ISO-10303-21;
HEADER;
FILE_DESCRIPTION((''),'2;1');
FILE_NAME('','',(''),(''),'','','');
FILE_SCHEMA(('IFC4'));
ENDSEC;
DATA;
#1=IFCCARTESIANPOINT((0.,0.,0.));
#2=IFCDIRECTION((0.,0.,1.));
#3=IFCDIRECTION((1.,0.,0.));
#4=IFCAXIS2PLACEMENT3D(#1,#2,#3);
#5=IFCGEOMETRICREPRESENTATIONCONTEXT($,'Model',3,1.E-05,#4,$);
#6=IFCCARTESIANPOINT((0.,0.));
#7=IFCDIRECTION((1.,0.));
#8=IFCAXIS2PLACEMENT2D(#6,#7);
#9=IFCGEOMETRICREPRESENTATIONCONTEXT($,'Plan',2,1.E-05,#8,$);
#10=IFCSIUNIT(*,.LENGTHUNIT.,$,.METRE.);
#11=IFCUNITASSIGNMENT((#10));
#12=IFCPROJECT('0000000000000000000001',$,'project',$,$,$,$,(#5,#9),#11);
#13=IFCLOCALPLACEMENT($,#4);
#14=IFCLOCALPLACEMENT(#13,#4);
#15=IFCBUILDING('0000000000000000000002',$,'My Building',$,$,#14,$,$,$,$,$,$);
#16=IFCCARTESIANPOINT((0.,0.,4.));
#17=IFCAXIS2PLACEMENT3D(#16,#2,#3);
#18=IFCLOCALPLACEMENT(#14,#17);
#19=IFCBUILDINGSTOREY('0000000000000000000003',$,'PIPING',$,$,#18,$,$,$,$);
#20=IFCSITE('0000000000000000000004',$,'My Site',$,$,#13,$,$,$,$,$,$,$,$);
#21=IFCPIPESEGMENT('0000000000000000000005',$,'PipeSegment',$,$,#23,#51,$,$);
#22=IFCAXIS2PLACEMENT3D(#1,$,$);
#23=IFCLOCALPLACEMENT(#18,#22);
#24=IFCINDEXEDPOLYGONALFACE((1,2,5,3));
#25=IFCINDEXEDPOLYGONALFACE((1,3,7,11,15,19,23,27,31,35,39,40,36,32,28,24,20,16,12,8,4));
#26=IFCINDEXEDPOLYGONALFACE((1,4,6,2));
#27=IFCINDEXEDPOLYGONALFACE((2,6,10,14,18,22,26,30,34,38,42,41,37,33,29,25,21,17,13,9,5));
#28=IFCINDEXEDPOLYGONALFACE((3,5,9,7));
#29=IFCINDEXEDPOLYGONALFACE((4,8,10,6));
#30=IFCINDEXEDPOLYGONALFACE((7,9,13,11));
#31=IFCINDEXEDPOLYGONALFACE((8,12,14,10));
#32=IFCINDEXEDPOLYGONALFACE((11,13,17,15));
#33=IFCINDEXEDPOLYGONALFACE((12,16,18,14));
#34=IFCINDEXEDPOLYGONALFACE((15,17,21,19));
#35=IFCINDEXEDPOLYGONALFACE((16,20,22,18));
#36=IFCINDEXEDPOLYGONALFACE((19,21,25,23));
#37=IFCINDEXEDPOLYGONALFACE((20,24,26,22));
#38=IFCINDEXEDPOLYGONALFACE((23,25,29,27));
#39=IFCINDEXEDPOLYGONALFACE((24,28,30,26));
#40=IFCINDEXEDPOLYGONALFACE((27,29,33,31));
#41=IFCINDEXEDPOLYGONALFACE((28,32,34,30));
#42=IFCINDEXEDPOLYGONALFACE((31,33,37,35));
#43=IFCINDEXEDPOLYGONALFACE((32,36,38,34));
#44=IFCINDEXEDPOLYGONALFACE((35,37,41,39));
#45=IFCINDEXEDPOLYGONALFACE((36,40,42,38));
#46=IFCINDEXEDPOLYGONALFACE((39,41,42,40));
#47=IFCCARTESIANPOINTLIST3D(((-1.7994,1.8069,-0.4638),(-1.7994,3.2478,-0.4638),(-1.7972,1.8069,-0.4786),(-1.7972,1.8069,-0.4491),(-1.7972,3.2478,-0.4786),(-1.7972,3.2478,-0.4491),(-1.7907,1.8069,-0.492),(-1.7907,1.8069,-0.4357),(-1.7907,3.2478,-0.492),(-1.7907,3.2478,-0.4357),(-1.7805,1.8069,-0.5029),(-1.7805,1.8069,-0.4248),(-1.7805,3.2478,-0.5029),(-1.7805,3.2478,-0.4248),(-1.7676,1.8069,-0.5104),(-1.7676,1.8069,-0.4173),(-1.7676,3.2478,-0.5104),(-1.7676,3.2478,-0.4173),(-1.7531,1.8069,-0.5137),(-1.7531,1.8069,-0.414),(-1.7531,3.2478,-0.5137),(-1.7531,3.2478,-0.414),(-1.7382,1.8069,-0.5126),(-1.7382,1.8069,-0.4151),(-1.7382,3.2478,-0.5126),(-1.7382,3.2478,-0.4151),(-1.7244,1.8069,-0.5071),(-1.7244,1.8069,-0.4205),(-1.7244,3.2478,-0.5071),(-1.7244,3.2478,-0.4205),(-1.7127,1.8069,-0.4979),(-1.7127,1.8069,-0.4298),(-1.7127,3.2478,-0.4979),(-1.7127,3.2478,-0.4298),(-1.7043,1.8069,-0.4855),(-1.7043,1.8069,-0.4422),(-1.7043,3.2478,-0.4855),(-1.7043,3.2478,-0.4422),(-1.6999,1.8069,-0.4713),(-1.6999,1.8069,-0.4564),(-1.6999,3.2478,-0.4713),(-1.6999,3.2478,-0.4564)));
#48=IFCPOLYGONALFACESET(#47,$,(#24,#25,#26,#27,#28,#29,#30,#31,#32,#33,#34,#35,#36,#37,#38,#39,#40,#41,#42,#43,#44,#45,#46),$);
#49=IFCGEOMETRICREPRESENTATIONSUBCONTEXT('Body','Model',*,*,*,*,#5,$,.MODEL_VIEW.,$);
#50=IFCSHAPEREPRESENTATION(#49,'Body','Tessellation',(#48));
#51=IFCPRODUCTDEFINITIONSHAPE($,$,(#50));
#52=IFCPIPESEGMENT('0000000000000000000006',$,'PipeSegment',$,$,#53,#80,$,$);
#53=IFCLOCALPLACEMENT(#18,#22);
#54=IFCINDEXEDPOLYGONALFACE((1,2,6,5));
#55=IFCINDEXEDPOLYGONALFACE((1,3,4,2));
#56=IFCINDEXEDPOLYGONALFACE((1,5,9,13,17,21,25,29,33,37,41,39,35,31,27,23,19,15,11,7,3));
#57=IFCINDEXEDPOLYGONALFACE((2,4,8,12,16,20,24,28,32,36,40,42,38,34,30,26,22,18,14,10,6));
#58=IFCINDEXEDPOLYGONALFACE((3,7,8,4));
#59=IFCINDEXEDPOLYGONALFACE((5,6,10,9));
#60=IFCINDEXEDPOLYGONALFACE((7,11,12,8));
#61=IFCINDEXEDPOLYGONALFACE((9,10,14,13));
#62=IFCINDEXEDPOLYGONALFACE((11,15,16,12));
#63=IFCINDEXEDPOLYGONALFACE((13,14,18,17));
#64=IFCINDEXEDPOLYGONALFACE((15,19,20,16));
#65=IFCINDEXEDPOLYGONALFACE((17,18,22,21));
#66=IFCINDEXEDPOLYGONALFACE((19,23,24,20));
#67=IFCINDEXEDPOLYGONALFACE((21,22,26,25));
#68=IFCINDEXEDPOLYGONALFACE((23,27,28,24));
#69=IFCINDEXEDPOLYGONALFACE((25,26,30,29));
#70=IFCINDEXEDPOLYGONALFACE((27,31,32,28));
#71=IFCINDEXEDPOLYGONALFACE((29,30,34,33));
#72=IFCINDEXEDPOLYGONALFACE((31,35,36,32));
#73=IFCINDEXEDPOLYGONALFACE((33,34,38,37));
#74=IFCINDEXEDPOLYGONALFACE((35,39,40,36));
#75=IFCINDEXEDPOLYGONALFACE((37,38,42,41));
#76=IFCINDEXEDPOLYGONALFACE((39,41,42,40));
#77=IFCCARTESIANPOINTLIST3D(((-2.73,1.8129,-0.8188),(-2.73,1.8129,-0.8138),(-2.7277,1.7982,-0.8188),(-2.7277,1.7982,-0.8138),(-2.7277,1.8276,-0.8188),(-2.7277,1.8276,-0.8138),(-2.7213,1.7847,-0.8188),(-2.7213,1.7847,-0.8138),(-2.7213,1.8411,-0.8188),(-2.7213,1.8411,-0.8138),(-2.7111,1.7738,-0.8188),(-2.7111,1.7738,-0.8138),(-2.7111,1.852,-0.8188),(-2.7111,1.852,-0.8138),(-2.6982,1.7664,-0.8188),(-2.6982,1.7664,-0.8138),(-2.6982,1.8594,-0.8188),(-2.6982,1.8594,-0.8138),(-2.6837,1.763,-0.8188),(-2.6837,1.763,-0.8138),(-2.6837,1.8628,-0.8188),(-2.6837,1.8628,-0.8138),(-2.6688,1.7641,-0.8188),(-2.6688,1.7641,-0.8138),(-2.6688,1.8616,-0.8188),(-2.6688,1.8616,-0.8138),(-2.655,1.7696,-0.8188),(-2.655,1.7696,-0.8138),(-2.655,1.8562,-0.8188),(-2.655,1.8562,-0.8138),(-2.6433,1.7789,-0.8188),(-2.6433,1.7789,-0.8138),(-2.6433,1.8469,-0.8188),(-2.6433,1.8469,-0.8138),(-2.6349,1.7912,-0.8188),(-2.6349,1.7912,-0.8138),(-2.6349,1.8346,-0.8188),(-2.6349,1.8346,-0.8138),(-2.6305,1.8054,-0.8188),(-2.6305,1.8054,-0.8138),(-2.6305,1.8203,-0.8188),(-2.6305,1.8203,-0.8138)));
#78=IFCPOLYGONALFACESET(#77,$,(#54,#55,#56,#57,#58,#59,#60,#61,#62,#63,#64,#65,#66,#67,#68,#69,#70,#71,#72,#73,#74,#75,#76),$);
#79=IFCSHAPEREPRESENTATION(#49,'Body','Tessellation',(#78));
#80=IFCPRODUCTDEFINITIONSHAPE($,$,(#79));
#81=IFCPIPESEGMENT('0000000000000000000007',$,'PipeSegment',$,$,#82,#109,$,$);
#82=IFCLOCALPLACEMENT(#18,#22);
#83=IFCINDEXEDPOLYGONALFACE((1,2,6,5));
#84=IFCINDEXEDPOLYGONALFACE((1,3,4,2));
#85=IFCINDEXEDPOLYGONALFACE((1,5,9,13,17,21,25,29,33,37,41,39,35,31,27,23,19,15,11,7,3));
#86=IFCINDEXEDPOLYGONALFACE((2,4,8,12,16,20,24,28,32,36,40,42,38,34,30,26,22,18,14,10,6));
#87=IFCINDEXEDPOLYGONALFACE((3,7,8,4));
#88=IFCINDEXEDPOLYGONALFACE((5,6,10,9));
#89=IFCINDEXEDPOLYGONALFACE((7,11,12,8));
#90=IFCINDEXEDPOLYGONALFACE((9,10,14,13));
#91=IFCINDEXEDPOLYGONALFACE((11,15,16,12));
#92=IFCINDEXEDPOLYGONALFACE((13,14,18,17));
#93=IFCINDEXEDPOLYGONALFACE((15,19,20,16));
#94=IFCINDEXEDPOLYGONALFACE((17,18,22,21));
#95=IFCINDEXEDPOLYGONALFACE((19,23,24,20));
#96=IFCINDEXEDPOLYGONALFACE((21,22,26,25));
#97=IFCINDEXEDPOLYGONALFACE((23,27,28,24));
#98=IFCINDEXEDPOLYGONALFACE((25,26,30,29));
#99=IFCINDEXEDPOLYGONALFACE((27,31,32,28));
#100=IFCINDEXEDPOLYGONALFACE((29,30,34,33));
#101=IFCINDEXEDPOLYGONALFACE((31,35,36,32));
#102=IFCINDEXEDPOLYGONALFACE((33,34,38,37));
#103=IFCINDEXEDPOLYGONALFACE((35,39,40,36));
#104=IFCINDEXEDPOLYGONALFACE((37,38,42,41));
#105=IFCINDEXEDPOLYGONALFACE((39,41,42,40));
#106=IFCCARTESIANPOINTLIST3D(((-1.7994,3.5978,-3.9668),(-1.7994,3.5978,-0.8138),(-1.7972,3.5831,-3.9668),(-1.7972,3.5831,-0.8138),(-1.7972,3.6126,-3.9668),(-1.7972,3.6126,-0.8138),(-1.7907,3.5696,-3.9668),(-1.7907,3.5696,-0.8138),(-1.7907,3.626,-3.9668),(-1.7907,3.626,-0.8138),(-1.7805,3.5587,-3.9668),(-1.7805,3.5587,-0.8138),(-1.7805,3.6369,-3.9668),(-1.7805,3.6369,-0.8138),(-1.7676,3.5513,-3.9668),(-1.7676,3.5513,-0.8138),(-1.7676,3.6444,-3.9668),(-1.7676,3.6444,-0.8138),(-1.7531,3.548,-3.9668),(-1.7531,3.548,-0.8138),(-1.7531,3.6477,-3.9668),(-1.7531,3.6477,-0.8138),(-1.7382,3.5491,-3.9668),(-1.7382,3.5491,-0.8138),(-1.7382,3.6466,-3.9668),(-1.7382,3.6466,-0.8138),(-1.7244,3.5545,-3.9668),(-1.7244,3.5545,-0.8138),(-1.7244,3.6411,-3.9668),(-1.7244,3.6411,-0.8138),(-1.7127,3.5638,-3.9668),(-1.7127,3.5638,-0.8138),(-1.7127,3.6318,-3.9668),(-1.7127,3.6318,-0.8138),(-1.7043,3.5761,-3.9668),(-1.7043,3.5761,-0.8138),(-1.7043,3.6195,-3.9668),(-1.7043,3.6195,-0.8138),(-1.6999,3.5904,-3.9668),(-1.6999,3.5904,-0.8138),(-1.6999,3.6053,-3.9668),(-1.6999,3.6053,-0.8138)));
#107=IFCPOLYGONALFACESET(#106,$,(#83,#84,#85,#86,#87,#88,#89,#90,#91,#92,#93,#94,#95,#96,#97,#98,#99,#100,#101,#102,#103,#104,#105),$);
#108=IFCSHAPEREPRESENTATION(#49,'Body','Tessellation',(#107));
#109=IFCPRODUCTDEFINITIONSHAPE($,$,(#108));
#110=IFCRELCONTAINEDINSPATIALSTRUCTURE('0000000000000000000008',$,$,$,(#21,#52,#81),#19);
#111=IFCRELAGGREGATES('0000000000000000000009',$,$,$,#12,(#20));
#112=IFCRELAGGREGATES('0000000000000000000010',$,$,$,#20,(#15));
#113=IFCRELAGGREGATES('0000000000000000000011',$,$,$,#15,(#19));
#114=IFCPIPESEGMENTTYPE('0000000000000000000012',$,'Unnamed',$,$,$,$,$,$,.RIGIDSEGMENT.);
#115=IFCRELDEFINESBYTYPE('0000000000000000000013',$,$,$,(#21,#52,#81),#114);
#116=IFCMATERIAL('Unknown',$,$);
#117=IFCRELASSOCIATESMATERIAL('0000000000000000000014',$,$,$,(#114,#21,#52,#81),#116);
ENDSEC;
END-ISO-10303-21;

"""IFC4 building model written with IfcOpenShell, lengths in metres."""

from ifc_helpers import new_model, si_unit, frame, origin_with_axes, origin_2d_with_axis, place, context, subcontext, project, spatial, circle, extrude, material, material_profile, profile_set, profile_usage, type_object, element, save


model = new_model("IFC4")

# Units and contexts
model_context = context("Model", 3, precision=1e-05, world=origin_with_axes())
plan_context = context("Plan", 2, precision=1e-05, world=origin_2d_with_axis())
body_context = subcontext(model_context, "Body", "Model", "MODEL_VIEW")
ifc_project = project(units=[si_unit("LENGTHUNIT", "METRE")], contexts=[model_context, plan_context])

# Site, building, storey
site_placement = place(None, origin_with_axes())
site = spatial("IfcSite", under=ifc_project, at=site_placement, Name="My Site")
building_placement = place(site_placement, origin_with_axes())
building = spatial("IfcBuilding", under=site, at=building_placement, Name="My Building")
storey_placement = place(building_placement, frame((0.0, 0.0, 4.0), z_axis=(0.0, 0.0, 1.0), x_axis=(1.0, 0.0, 0.0)))
storey = spatial("IfcBuildingStorey", under=building, at=storey_placement, Name="PIPING")

# Pipe segments
ifc_material = material(Name="Unknown")
ifc_material_profile = material_profile(ifc_material, circle(Radius=0.05))
ifc_profile_set = profile_set([ifc_material_profile])
pipe_segment_type = type_object("IfcPipeSegmentType", Name="Unnamed", PredefinedType="RIGIDSEGMENT", material=ifc_profile_set)
ifc_profile_usage_1 = profile_usage(ifc_profile_set, cardinal=5)
pipe_segment_1_placement = place(storey_placement, frame((-1.7494, 1.8069, -0.4638), z_axis=(0.0, 1.0, 0.0), x_axis=(-1.0, 0.0, 0.0)))
element("IfcPipeSegment", 1, at=pipe_segment_1_placement, inside=storey, type_object=pipe_segment_type, material=ifc_profile_usage_1, Name="PipeSegment", context=body_context, shape_type="SweptSolid", body=[
    extrude(circle(Radius=0.05), origin_with_axes(), (0.0, 0.0, 1.0), 1.4409),
])
ifc_profile_usage_2 = profile_usage(ifc_profile_set, cardinal=5)
pipe_segment_2_placement = place(storey_placement, frame((-2.68, 1.8129, -0.8138), z_axis=(0.0, 0.0, -1.0), x_axis=(-1.0, 0.0, 0.0)))
element("IfcPipeSegment", 2, at=pipe_segment_2_placement, inside=storey, type_object=pipe_segment_type, material=ifc_profile_usage_2, Name="PipeSegment", context=body_context, shape_type="SweptSolid", body=[
    extrude(circle(Radius=0.05), origin_with_axes(), (0.0, 0.0, 1.0), 0.0049),
])
ifc_profile_usage_3 = profile_usage(ifc_profile_set, cardinal=5)
pipe_segment_3_placement = place(storey_placement, frame((-1.7494, 3.5978, -0.8138), z_axis=(0.0, 0.0, -1.0), x_axis=(-1.0, 0.0, 0.0)))
element("IfcPipeSegment", 3, at=pipe_segment_3_placement, inside=storey, type_object=pipe_segment_type, material=ifc_profile_usage_3, Name="PipeSegment", context=body_context, shape_type="SweptSolid", body=[
    extrude(circle(Radius=0.05), origin_with_axes(), (0.0, 0.0, 1.0), 3.1529),
])

save(model, "model.ifc")
